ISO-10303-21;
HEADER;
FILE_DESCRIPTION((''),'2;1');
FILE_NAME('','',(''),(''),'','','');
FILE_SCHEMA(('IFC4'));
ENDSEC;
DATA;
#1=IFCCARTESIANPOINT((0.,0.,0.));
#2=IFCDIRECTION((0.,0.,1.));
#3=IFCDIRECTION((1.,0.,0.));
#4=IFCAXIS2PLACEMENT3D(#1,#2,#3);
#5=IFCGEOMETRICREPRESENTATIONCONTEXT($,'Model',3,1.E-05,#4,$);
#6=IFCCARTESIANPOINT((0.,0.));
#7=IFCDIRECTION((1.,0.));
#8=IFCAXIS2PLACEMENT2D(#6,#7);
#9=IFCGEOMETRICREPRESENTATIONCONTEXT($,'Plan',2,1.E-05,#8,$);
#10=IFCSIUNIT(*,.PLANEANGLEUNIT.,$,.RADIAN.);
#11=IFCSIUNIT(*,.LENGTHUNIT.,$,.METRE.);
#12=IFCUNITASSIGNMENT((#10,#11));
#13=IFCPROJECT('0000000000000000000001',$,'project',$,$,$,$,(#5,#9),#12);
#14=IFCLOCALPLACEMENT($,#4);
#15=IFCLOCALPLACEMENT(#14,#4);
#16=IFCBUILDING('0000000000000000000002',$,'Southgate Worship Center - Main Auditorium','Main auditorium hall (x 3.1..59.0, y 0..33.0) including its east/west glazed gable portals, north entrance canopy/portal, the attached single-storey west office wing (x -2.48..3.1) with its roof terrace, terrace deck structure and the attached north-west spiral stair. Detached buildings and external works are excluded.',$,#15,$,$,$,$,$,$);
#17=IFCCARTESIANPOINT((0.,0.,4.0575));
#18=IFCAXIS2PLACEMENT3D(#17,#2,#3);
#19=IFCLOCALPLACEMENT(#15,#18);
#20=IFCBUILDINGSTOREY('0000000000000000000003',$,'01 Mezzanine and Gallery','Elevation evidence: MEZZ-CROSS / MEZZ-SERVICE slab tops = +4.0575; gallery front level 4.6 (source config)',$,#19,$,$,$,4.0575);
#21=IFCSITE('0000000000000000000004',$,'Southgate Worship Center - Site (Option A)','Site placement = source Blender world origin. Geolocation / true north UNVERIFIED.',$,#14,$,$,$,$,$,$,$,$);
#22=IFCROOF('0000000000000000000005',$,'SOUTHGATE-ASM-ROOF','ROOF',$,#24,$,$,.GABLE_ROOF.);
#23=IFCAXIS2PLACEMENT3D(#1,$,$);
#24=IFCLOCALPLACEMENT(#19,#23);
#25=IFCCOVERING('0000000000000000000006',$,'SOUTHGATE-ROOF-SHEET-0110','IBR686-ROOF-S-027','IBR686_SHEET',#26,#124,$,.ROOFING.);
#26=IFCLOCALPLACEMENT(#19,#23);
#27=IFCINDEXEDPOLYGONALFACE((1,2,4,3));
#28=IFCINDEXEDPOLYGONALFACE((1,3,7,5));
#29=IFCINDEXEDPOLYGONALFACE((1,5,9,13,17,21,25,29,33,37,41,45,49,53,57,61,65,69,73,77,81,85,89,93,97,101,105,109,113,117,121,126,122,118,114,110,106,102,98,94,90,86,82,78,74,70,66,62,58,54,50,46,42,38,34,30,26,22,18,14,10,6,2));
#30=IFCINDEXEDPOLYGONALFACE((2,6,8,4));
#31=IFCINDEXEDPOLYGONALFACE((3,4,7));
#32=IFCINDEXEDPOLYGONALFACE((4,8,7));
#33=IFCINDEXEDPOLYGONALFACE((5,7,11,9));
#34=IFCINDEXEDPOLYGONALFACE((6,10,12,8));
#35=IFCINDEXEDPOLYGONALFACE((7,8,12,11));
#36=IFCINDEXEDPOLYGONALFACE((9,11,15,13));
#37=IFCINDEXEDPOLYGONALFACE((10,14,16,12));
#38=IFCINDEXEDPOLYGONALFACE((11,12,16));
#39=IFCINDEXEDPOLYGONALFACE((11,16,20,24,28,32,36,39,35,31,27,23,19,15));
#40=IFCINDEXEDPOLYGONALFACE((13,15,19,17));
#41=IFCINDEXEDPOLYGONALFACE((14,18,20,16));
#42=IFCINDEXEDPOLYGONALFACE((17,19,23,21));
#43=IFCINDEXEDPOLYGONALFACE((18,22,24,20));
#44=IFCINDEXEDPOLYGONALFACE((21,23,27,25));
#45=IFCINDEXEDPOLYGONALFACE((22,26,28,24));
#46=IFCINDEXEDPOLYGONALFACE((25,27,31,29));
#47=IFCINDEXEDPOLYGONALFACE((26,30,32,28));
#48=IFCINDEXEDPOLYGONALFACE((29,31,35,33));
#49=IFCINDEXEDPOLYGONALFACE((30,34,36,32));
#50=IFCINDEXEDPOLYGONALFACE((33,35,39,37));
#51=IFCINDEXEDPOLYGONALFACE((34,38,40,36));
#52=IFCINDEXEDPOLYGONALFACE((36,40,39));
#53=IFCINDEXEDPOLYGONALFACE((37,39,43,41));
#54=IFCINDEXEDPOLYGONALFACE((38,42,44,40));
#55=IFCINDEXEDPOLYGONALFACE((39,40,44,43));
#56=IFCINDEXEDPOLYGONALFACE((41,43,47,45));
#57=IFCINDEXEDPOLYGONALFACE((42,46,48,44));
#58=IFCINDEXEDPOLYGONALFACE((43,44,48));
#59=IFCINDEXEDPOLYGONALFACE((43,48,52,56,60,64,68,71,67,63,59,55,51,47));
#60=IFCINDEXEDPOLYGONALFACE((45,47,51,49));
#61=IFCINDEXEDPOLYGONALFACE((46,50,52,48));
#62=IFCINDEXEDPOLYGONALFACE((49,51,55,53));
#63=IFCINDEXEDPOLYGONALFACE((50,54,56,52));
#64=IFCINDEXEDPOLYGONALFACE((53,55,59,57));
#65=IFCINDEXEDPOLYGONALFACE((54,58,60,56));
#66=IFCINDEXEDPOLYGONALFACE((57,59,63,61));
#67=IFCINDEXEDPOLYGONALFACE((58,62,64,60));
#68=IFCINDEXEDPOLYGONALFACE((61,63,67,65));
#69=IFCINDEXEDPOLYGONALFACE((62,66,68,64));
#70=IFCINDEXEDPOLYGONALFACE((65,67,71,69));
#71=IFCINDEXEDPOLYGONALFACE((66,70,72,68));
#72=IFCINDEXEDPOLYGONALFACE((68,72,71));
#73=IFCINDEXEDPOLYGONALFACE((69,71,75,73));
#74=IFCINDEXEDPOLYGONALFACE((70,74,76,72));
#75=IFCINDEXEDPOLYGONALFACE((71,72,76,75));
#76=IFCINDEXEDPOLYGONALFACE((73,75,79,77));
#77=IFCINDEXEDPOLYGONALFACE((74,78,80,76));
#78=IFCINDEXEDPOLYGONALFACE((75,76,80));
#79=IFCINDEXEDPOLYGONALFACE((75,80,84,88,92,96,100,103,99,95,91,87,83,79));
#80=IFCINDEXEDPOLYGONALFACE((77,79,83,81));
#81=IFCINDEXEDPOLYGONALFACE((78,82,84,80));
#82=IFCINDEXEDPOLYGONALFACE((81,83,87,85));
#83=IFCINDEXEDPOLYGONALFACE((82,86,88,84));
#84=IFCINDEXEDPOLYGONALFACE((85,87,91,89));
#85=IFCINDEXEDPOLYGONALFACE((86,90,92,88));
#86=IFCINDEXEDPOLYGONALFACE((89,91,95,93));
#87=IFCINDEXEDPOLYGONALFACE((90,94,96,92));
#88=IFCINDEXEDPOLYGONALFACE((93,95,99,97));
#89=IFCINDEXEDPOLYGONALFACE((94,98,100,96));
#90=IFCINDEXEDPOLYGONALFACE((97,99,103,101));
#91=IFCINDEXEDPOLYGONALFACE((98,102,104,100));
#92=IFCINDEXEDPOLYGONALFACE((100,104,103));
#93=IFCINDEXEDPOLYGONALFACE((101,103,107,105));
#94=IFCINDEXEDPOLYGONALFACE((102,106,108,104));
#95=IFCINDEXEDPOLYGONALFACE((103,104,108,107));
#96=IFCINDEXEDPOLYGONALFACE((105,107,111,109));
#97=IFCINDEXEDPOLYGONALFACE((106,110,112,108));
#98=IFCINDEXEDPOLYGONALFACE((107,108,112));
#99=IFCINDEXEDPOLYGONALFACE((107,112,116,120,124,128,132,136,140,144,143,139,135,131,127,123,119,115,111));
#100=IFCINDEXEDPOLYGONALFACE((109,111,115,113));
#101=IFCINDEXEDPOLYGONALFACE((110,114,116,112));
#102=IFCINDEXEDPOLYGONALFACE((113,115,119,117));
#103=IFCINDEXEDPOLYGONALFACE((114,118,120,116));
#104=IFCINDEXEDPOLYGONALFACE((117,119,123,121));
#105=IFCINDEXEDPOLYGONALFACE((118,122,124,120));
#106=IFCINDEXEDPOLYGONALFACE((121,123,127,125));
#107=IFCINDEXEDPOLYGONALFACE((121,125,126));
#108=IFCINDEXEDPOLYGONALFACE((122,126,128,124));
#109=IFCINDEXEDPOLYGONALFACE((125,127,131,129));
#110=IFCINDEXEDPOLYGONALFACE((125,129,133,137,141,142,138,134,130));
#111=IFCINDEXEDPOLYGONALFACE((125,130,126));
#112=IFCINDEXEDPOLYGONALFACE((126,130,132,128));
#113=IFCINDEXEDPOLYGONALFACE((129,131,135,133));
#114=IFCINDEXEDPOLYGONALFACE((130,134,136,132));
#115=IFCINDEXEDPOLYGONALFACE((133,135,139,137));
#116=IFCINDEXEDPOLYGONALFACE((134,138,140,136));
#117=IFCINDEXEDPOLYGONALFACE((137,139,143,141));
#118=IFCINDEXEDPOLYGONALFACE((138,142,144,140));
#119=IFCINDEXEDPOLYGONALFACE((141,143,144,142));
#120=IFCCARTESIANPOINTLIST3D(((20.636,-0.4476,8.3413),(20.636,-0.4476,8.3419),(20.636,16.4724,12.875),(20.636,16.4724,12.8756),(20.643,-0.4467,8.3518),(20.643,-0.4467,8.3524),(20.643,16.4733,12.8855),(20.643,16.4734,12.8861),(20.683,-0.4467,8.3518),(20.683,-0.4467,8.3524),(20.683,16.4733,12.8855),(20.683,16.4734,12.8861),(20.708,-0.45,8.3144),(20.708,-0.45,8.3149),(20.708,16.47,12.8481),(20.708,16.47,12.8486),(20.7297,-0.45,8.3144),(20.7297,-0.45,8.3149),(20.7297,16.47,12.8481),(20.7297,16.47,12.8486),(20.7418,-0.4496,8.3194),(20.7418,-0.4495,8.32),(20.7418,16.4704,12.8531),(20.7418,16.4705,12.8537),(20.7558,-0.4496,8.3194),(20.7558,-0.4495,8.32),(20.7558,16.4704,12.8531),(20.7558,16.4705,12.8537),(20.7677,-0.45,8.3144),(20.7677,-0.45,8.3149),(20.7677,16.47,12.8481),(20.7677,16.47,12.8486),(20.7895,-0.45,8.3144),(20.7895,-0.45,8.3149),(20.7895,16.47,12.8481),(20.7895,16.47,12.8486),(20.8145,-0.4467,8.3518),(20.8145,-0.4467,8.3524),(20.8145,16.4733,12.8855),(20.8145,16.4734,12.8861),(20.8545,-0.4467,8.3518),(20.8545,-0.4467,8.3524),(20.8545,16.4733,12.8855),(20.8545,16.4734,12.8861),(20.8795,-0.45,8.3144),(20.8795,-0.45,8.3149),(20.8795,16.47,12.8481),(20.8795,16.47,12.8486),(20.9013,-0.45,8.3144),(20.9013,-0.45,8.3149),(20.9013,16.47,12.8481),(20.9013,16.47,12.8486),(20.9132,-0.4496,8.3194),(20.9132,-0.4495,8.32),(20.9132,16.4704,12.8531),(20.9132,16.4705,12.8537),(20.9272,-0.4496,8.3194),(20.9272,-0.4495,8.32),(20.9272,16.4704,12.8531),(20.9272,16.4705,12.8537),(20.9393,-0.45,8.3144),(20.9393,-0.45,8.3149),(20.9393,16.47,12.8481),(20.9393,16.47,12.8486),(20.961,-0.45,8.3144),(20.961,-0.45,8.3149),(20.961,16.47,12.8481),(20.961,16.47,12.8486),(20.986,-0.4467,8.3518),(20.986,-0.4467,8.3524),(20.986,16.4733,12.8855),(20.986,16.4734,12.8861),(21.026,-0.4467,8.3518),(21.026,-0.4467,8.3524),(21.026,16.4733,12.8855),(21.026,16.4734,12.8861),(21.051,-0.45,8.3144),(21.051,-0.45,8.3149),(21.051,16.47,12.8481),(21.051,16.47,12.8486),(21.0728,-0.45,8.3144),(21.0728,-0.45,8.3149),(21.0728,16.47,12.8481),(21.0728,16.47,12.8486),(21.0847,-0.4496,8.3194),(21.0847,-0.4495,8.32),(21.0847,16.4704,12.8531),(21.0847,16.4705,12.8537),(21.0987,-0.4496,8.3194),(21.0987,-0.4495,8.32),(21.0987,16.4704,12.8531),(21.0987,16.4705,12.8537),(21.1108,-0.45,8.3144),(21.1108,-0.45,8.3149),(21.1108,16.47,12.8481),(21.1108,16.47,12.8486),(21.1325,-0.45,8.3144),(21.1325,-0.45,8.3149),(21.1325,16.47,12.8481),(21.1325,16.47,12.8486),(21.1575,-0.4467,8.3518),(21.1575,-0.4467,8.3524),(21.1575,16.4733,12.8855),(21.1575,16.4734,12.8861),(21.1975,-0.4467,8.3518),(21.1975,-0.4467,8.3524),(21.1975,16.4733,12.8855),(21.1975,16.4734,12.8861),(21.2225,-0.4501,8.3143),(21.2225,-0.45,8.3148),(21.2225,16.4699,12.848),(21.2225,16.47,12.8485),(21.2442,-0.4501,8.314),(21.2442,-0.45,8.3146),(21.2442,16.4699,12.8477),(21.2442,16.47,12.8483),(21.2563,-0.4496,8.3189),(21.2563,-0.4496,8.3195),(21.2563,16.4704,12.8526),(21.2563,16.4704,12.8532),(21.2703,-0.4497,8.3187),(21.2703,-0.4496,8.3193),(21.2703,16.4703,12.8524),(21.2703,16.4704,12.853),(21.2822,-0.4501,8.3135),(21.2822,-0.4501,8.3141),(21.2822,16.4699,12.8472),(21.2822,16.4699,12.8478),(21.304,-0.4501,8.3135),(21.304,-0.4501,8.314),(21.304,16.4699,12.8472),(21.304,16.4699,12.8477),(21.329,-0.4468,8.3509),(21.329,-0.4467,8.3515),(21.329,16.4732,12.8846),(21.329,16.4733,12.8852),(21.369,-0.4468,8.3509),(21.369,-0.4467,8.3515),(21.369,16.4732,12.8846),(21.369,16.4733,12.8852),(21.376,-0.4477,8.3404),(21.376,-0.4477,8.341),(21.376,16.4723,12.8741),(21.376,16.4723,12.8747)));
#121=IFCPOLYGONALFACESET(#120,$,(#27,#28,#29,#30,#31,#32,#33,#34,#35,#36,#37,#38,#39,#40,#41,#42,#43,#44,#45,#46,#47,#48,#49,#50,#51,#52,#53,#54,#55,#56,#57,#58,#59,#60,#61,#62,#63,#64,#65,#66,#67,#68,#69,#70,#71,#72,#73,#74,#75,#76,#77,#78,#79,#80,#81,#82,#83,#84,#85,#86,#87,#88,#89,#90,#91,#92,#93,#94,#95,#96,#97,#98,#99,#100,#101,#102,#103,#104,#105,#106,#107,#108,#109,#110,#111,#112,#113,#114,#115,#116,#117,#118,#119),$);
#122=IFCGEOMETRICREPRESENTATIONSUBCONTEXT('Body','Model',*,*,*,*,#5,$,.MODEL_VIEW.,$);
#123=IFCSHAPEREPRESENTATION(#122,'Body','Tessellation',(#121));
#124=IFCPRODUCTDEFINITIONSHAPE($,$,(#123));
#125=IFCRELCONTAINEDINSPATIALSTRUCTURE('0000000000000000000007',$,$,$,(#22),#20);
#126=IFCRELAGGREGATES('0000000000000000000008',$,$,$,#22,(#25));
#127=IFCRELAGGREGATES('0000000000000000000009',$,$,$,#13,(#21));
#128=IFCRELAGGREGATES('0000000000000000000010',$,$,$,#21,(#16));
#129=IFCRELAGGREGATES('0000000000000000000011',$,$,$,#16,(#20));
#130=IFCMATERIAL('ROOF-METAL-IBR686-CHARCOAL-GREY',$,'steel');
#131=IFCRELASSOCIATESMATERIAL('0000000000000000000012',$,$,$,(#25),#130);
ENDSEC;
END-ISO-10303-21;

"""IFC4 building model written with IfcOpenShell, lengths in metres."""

from ifc_helpers import new_model, si_unit, frame, origin_with_axes, origin_2d_with_axis, place, context, subcontext, project, spatial, indexed_curve, outline, extrude, clip, halfspace, material, element, aggregate, save


model = new_model("IFC4")

# Units and contexts
model_context = context("Model", 3, precision=1e-05, world=origin_with_axes())
plan_context = context("Plan", 2, precision=1e-05, world=origin_2d_with_axis())
body_context = subcontext(model_context, "Body", "Model", "MODEL_VIEW")
ifc_project = project(units=[si_unit("PLANEANGLEUNIT", "RADIAN"), si_unit("LENGTHUNIT", "METRE")], contexts=[model_context, plan_context])

# Site, building, storey
site_placement = place(None, origin_with_axes())
site = spatial("IfcSite", under=ifc_project, at=site_placement, Name="Southgate Worship Center - Site (Option A)", Description="Site placement = source Blender world origin. Geolocation / true north UNVERIFIED.")
building_placement = place(site_placement, origin_with_axes())
building = spatial("IfcBuilding", under=site, at=building_placement, Name="Southgate Worship Center - Main Auditorium", Description="Main auditorium hall (x 3.1..59.0, y 0..33.0) including its east/west glazed gable portals, north entrance canopy/portal, the attached single-storey west office wing (x -2.48..3.1) with its roof terrace, terrace deck structure and the attached north-west spiral stair. Detached buildings and external works are excluded.")
storey_placement = place(building_placement, frame((0.0, 0.0, 4.0575), z_axis=(0.0, 0.0, 1.0), x_axis=(1.0, 0.0, 0.0)))
storey = spatial("IfcBuildingStorey", under=building, at=storey_placement, Name="01 Mezzanine and Gallery", Description="Elevation evidence: MEZZ-CROSS / MEZZ-SERVICE slab tops = +4.0575; gallery front level 4.6 (source config)", Elevation=4.0575)

# Roof, covering
roof_placement = place(storey_placement, origin_with_axes())
roof = element("IfcRoof", 1, at=roof_placement, inside=storey, Name="SOUTHGATE-ASM-ROOF", Description="ROOF", PredefinedType="GABLE_ROOF")
ifc_material_1 = material(Name="ROOF-METAL-IBR686-CHARCOAL-GREY", Category="steel")
covering_1_placement = place(roof_placement, frame((20.636, -0.4501, 8.3135), z_axis=(0.0, 0.0, 1.0), x_axis=(1.0, 0.0, 0.0)))
covering_1 = element("IfcCovering", 2, at=covering_1_placement, material=ifc_material_1, Name="SOUTHGATE-ROOF-SHEET-0110", Description="IBR686-ROOF-S-027", ObjectType="IBR686_SHEET", PredefinedType="ROOFING", context=body_context, shape_type="Clipping", body=[
    clip(clip(extrude(outline(indexed_curve([(0.0, 0.0), (0.025, 0.0353), (0.065, 0.0353), (0.072, 0.0254), (0.072, 0.0259), (0.065, 0.0358), (0.025, 0.0358), (0.0, 0.0005), (-0.0217, 0.0005), (-0.0338, 0.0053), (-0.0478, 0.0053), (-0.0597, 0.0005), (-0.0815, 0.0005), (-0.1065, 0.0358), (-0.1465, 0.0358), (-0.1715, 0.0005), (-0.1933, 0.0005), (-0.2052, 0.0053), (-0.2192, 0.0053), (-0.2313, 0.0005), (-0.253, 0.0005), (-0.278, 0.0358), (-0.318, 0.0358), (-0.343, 0.0005), (-0.3647, 0.0005), (-0.3767, 0.0053), (-0.3907, 0.0053), (-0.4028, 0.0005), (-0.4245, 0.0005), (-0.4495, 0.0358), (-0.4895, 0.0358), (-0.5145, 0.0004), (-0.5362, 0.0002), (-0.5483, 0.0048), (-0.5623, 0.0046), (-0.5742, -0.0003), (-0.596, -0.0004), (-0.621, 0.0349), (-0.661, 0.0349), (-0.668, 0.0251), (-0.668, 0.0246), (-0.661, 0.0344), (-0.621, 0.0344), (-0.596, -0.0009), (-0.5742, -0.0008), (-0.5623, 0.0041), (-0.5483, 0.0043), (-0.5362, -0.0003), (-0.5145, -0.0001), (-0.4895, 0.0353), (-0.4495, 0.0353), (-0.4245, 0.0), (-0.4028, 0.0), (-0.3907, 0.0048), (-0.3767, 0.0048), (-0.3647, 0.0), (-0.343, 0.0), (-0.318, 0.0353), (-0.278, 0.0353), (-0.253, 0.0), (-0.2313, 0.0), (-0.2192, 0.0048), (-0.2052, 0.0048), (-0.1933, 0.0), (-0.1715, 0.0), (-0.1465, 0.0353), (-0.1065, 0.0353), (-0.0815, 0.0), (-0.0597, 0.0), (-0.0478, 0.0048), (-0.0338, 0.0048), (-0.0217, 0.0), (0.0, 0.0)], self_intersect=False)), frame((0.072, -0.0003, 0.0008), z_axis=(0.0, 0.965926, 0.258819), x_axis=(-1.0, 0.0, 0.0)), (0.0, 0.0, 1.0), 17.5303), halfspace(frame((0.37, 0.0012, 0.014), z_axis=(0.0, -0.996022, 0.089113), x_axis=(1.0, 0.0, 0.0)), False)), halfspace(frame((0.37, 16.9212, 4.5477), z_axis=(0.0, 0.996021, -0.089119), x_axis=(-1.0, 0.0, 0.0)), False)),
])
aggregate(roof, [covering_1])

save(model, "model.ifc")
